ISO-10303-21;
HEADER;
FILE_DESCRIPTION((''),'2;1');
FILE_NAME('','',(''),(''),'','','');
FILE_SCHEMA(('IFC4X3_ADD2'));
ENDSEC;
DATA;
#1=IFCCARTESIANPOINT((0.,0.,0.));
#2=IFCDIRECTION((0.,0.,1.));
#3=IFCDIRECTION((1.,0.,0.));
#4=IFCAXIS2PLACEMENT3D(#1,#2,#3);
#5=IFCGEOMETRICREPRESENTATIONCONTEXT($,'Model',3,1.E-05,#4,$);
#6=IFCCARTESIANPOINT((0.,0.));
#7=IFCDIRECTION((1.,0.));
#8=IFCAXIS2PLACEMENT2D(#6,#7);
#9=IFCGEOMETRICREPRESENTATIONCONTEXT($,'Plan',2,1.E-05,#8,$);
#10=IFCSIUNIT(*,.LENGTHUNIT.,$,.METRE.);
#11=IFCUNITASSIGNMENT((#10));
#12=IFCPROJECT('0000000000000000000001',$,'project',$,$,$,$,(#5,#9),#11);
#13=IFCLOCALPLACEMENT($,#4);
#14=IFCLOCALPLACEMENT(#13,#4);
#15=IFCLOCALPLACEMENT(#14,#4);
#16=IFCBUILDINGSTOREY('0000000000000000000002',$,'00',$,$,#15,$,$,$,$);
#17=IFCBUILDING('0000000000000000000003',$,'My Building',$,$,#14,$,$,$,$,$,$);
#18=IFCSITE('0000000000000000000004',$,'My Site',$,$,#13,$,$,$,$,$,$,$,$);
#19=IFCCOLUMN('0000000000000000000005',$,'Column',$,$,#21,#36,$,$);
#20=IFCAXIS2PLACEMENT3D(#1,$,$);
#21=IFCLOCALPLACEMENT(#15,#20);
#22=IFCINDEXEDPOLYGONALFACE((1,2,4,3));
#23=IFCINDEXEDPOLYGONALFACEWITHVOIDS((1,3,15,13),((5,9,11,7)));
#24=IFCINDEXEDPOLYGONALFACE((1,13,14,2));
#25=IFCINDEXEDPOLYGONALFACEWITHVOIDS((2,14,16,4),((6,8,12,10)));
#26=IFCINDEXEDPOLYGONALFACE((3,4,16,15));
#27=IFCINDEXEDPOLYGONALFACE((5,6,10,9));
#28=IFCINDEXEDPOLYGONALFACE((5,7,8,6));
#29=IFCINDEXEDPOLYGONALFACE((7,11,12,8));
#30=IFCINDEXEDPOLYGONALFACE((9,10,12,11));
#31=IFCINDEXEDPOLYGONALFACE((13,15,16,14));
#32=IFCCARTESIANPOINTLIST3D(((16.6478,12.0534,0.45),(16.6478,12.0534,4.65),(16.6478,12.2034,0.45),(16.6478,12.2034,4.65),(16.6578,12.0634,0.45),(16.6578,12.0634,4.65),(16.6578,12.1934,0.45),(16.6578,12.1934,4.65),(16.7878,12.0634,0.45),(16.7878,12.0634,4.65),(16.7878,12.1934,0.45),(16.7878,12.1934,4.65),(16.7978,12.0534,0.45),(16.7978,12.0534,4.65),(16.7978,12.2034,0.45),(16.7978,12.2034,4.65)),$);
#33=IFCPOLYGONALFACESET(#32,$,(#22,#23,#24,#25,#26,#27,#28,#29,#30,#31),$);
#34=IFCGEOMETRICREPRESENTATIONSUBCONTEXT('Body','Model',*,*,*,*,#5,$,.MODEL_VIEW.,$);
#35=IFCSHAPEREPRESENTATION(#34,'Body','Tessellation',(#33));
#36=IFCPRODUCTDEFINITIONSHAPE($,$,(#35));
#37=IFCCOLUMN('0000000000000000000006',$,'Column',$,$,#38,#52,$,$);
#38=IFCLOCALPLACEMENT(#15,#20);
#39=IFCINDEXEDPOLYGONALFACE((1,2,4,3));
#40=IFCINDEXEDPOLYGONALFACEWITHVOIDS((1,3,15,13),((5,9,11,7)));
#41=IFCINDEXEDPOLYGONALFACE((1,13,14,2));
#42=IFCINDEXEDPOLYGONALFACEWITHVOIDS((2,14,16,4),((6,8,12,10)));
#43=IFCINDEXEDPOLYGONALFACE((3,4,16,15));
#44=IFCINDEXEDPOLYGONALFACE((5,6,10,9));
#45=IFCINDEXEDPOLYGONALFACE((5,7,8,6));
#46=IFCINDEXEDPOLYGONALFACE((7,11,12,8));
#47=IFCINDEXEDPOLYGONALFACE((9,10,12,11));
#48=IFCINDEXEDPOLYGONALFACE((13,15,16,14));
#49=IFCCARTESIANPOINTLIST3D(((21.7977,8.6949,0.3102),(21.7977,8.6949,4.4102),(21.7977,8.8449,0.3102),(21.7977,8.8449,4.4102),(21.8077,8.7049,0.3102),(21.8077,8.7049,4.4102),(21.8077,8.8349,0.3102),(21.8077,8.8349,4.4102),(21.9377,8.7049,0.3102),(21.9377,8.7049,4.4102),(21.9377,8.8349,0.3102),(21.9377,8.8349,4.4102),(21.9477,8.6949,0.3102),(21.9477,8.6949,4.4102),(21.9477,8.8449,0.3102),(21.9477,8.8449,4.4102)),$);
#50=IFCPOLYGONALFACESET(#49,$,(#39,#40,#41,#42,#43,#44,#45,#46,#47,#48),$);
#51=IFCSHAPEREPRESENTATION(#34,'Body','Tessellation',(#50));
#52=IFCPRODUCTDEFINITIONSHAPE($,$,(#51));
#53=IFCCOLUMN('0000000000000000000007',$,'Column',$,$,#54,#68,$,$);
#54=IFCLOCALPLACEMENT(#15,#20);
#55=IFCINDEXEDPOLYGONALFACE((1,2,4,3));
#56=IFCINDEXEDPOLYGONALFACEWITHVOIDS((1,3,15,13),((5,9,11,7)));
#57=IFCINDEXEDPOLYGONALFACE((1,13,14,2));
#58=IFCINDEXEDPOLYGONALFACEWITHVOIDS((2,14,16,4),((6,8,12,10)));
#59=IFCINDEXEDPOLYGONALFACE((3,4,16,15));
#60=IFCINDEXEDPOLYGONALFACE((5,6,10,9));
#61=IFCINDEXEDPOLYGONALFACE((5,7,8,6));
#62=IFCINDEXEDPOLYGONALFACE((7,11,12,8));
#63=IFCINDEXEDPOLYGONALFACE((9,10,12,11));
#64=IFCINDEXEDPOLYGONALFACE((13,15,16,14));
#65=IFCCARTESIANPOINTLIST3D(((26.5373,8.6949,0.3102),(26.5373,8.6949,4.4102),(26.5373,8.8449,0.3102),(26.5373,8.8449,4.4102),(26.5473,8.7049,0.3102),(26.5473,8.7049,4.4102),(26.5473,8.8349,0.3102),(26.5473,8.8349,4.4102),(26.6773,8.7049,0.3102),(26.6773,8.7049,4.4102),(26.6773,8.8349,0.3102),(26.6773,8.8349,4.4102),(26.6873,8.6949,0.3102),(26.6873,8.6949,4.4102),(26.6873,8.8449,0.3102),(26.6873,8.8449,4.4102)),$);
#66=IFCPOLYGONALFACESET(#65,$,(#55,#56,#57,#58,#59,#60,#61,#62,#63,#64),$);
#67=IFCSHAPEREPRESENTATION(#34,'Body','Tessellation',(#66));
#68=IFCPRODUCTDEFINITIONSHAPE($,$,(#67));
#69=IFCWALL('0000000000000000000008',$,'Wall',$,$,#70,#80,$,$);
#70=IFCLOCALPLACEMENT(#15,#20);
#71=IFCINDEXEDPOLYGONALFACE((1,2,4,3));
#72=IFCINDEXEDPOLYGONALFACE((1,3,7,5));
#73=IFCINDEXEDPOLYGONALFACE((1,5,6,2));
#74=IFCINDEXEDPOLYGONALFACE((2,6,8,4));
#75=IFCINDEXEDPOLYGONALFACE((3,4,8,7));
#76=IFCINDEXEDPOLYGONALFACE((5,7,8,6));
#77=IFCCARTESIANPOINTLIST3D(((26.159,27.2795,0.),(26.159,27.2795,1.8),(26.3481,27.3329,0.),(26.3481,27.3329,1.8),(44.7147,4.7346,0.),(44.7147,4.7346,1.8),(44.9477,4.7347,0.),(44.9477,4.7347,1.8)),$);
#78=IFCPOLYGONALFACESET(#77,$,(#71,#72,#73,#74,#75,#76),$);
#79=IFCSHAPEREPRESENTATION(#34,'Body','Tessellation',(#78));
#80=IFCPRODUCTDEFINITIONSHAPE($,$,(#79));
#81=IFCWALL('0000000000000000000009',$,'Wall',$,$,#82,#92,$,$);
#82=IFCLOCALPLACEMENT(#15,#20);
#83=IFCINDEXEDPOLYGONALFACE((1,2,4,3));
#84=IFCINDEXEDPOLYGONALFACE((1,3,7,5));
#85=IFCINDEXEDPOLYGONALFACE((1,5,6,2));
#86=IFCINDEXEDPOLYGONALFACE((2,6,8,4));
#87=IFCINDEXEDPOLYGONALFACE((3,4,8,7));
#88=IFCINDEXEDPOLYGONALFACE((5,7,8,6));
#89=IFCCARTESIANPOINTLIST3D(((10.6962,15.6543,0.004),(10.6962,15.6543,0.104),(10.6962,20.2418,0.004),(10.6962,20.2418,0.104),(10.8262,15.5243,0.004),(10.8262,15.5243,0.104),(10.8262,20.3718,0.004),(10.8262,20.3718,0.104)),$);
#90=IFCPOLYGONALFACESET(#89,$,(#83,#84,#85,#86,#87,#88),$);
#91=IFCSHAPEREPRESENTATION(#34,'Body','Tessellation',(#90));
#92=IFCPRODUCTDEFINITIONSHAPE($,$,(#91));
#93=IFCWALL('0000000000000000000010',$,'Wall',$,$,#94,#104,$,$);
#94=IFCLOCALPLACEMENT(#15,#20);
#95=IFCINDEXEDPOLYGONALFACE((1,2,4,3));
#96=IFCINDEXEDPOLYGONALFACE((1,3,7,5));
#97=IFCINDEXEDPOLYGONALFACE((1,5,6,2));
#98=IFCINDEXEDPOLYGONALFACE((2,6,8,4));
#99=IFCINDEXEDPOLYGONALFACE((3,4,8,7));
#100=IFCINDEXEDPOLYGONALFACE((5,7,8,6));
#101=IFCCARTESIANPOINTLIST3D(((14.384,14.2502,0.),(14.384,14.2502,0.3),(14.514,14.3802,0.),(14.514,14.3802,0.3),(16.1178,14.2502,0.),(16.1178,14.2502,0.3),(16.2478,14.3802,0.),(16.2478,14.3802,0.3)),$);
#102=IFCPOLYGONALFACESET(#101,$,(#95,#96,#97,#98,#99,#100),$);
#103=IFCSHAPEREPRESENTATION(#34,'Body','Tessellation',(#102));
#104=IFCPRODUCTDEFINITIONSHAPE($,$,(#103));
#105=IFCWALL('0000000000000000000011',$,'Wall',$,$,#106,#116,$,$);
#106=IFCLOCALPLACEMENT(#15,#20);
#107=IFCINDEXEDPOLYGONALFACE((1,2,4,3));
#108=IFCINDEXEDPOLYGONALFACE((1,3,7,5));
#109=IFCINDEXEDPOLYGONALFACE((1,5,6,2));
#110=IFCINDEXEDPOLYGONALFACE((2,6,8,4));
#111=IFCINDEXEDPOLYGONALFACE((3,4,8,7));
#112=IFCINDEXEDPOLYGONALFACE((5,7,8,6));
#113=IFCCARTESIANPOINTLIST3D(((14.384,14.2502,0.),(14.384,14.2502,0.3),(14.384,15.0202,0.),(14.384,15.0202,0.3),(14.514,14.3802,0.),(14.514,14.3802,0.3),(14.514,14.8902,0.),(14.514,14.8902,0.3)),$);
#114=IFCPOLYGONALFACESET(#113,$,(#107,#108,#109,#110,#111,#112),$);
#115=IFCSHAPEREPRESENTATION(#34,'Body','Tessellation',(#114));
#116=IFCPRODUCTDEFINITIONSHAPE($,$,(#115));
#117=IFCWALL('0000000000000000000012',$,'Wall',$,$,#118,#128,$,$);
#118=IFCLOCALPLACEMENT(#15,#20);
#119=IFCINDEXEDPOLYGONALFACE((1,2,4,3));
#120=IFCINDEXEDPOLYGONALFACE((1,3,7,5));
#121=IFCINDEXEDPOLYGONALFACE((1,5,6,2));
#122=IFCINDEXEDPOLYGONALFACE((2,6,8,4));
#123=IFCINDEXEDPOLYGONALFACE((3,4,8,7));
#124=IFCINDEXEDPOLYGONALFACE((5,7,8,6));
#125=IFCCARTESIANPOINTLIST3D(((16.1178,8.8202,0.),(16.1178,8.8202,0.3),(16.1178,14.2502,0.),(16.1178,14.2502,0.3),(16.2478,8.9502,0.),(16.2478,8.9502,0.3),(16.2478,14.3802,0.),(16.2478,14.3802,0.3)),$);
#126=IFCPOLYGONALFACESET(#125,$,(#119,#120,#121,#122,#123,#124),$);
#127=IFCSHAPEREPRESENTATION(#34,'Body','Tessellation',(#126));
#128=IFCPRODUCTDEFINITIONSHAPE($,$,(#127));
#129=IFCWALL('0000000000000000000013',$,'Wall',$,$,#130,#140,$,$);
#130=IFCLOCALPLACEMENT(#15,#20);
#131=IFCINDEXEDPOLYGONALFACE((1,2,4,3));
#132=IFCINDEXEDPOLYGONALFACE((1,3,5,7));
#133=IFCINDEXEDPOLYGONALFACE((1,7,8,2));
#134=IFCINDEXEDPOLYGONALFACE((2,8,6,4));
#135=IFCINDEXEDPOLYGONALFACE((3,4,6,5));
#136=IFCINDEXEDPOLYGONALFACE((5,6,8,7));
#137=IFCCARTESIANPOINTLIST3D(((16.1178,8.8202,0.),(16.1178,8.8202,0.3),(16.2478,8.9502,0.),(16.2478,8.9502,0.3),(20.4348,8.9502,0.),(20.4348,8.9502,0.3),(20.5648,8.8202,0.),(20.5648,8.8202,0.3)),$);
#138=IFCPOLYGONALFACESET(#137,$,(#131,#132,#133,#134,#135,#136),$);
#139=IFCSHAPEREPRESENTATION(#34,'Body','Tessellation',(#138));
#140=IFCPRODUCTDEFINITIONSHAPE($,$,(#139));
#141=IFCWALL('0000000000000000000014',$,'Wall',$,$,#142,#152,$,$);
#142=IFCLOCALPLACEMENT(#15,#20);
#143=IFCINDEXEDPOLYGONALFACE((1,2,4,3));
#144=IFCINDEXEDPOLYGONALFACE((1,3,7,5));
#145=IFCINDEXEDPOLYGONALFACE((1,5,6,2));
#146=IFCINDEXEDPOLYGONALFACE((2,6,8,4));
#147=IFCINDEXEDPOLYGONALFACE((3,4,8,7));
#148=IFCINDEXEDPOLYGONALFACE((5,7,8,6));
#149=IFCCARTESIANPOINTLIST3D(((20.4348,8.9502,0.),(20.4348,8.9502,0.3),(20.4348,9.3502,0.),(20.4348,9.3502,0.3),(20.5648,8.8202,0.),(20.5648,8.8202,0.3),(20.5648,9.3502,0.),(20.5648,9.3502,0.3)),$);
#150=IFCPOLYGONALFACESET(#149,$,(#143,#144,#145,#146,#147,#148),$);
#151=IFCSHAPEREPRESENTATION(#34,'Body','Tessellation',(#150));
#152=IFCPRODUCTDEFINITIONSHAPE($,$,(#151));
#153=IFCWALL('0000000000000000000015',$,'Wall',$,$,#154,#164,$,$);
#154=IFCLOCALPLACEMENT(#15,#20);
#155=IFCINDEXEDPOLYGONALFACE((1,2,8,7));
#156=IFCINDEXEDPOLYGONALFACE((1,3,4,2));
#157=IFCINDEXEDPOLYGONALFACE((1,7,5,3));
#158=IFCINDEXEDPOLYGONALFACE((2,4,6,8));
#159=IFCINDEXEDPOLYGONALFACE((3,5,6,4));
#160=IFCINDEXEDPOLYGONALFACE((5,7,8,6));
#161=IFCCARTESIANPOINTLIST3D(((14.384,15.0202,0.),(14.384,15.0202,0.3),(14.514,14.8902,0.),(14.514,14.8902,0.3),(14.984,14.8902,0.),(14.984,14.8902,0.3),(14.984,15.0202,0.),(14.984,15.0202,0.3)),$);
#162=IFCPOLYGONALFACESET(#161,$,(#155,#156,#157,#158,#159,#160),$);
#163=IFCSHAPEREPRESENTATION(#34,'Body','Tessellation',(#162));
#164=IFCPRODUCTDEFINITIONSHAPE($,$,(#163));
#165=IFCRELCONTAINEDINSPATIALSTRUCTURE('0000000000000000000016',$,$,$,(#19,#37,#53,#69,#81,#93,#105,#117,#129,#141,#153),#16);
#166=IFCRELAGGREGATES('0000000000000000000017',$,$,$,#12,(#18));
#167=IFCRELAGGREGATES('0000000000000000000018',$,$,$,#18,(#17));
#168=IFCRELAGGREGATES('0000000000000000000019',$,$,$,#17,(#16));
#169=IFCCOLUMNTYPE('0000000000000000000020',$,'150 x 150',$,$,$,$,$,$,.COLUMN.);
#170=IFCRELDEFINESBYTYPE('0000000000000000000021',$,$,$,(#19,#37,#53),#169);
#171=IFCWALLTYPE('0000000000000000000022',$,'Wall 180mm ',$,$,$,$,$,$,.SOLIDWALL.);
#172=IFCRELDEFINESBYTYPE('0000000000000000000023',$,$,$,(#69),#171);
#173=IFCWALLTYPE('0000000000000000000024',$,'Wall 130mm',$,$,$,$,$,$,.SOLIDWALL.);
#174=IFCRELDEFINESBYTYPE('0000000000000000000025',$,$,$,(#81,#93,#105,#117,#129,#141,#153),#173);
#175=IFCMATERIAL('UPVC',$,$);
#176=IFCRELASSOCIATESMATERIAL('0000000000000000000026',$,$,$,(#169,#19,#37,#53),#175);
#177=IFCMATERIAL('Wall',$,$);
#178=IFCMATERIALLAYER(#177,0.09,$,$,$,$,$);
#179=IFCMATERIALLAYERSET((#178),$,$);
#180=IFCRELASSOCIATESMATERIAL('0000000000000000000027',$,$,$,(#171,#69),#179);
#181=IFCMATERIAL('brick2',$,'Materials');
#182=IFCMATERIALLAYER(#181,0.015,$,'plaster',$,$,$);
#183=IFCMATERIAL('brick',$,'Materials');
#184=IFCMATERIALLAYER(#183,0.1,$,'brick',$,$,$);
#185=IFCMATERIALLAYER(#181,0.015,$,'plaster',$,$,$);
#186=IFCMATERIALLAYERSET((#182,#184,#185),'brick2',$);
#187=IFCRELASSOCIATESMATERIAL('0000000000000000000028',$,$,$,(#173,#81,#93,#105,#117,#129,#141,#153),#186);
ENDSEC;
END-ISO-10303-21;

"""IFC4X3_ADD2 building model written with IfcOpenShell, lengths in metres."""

from ifc_helpers import new_model, entity, si_unit, frame, origin_with_axes, origin_2d_with_axis, place, context, subcontext, project, spatial, line, indexed_curve, hollow_rectangle, outline, extrude, clip, halfspace, shape, material, layer, layer_set, layer_usage, material_profile, profile_set, profile_usage, type_object, element, save


model = new_model("IFC4X3_ADD2")

# Units and contexts
model_context = context("Model", 3, precision=1e-05, world=origin_with_axes())
plan_context = context("Plan", 2, precision=1e-05, world=origin_2d_with_axis())
body_context_1 = subcontext(model_context, "Body", "Model", "MODEL_VIEW")
body_context_2 = subcontext(plan_context, "Body", "Plan", "PLAN_VIEW")
ifc_project = project(units=[si_unit("LENGTHUNIT", "METRE")], contexts=[model_context, plan_context])

# Site, building, storey
site_placement = place(None, origin_with_axes())
site = spatial("IfcSite", under=ifc_project, at=site_placement, Name="My Site")
building_placement = place(site_placement, origin_with_axes())
building = spatial("IfcBuilding", under=site, at=building_placement, Name="My Building")
storey_placement = place(building_placement, origin_with_axes())
storey = spatial("IfcBuildingStorey", under=building, at=storey_placement, Name="00")

# Columns
ifc_material_1 = material(Name="UPVC")
ifc_material_profile = material_profile(ifc_material_1, hollow_rectangle(XDim=0.15, YDim=0.15, WallThickness=0.01))
ifc_profile_set = profile_set([ifc_material_profile])
column_type = type_object("IfcColumnType", Name="150 x 150", PredefinedType="COLUMN", material=ifc_profile_set)
ifc_profile_usage_1 = profile_usage(ifc_profile_set, cardinal=5)
column_1_placement = place(storey_placement, frame((16.7228, 12.1284, 0.45), z_axis=(0.0, 0.0, 1.0), x_axis=(1.0, 0.0, 0.0)))
element("IfcColumn", 1, at=column_1_placement, inside=storey, type_object=column_type, material=ifc_profile_usage_1, Name="Column", shapes=[
    shape(body_context_1, "Body", "SweptSolid", [extrude(hollow_rectangle(XDim=0.15, YDim=0.15, WallThickness=0.01), origin_with_axes(), (0.0, 0.0, 1.0), 4.2)]),
    shape(body_context_2, "Body", "Annotation2D", [entity("IfcGeometricCurveSet", [entity("IfcIndexedPolyCurve", entity("IfcCartesianPointList2D", [[-0.075, -0.075], [-0.075, 0.075], [0.075, 0.075], [0.075, -0.075]]), [entity("IfcLineIndex", [1, 2, 3, 4, 1])]), entity("IfcIndexedPolyCurve", entity("IfcCartesianPointList2D", [[-0.065, 0.065], [-0.065, -0.065], [0.065, -0.065], [0.065, 0.065]]), [entity("IfcLineIndex", [1, 2, 3, 4, 1])])])]),
])
ifc_profile_usage_2 = profile_usage(ifc_profile_set, cardinal=5)
column_2_placement = place(storey_placement, frame((21.8727, 8.7699, 0.3102), z_axis=(0.0, 0.0, 1.0), x_axis=(1.0, 0.0, 0.0)))
element("IfcColumn", 2, at=column_2_placement, inside=storey, type_object=column_type, material=ifc_profile_usage_2, Name="Column", shapes=[
    shape(body_context_1, "Body", "SweptSolid", [extrude(hollow_rectangle(XDim=0.15, YDim=0.15, WallThickness=0.01), origin_with_axes(), (0.0, 0.0, 1.0), 4.1)]),
    shape(body_context_2, "Body", "Annotation2D", [entity("IfcGeometricCurveSet", [entity("IfcIndexedPolyCurve", entity("IfcCartesianPointList2D", [[-0.075, -0.075], [-0.075, 0.075], [0.075, 0.075], [0.075, -0.075]]), [entity("IfcLineIndex", [1, 2, 3, 4, 1])]), entity("IfcIndexedPolyCurve", entity("IfcCartesianPointList2D", [[-0.065, -0.065], [0.065, -0.065], [0.065, 0.065], [-0.065, 0.065]]), [entity("IfcLineIndex", [1, 2, 3, 4, 1])])])]),
])
ifc_profile_usage_3 = profile_usage(ifc_profile_set, cardinal=5)
column_3_placement = place(storey_placement, frame((26.6123, 8.7699, 0.3102), z_axis=(0.0, 0.0, 1.0), x_axis=(1.0, 0.0, 0.0)))
element("IfcColumn", 3, at=column_3_placement, inside=storey, type_object=column_type, material=ifc_profile_usage_3, Name="Column", shapes=[
    shape(body_context_1, "Body", "SweptSolid", [extrude(hollow_rectangle(XDim=0.15, YDim=0.15, WallThickness=0.01), origin_with_axes(), (0.0, 0.0, 1.0), 4.1)]),
    shape(body_context_2, "Body", "Annotation2D", [entity("IfcGeometricCurveSet", [entity("IfcIndexedPolyCurve", entity("IfcCartesianPointList2D", [[-0.075, -0.075], [-0.075, 0.075], [0.075, 0.075], [0.075, -0.075]]), [entity("IfcLineIndex", [1, 2, 3, 4, 1])]), entity("IfcIndexedPolyCurve", entity("IfcCartesianPointList2D", [[-0.065, -0.065], [0.065, -0.065], [0.065, 0.065], [-0.065, 0.065]]), [entity("IfcLineIndex", [1, 2, 3, 4, 1])])])]),
])

# Walls
ifc_material_2 = material(Name="Wall")
ifc_layer_1 = layer(ifc_material_2, 0.09)
ifc_layer_set_1 = layer_set([ifc_layer_1])
wall_type_1 = type_object("IfcWallType", Name="Wall 180mm ", PredefinedType="SOLIDWALL", material=ifc_layer_set_1)
ifc_layer_usage_1 = layer_usage(ifc_layer_set_1, "AXIS2", "POSITIVE", 0.0)
wall_1_placement = place(storey_placement, frame((44.9477, 4.7347, 0.0), z_axis=(0.0, 0.0, 1.0), x_axis=(-0.635489, 0.77211, 0.0)))
element("IfcWall", 4, at=wall_1_placement, inside=storey, type_object=wall_type_1, material=ifc_layer_usage_1, Name="Wall", context=body_context_1, shape_type="Clipping", body=[
    clip(clip(extrude(outline(indexed_curve([(0.0, 0.0), (0.0, 0.18), (29.3471, 0.18), (29.3471, 0.0), (0.0, 0.0)], self_intersect=False)), origin_with_axes(), (0.0, 0.0, 1.0), 1.8), halfspace(frame((0.0, 0.0, 0.0), z_axis=(-0.772377, 0.635165, 0.0), x_axis=(0.635165, 0.772377, 0.0)), False)), halfspace(frame((29.2681, 0.0, 0.0), z_axis=(0.915717, -0.401825, 0.0), x_axis=(-0.401825, -0.915717, 0.0)), False)),
])
ifc_material_3 = material(Name="brick2", Category="Materials")
ifc_layer_2 = layer(ifc_material_3, 0.015, Name="plaster")
ifc_material_4 = material(Name="brick", Category="Materials")
ifc_layer_3 = layer(ifc_material_4, 0.1, Name="brick")
ifc_layer_4 = layer(ifc_material_3, 0.015, Name="plaster")
ifc_layer_set_2 = layer_set([ifc_layer_2, ifc_layer_3, ifc_layer_4], Name="brick2")
ifc_layer_usage_2 = layer_usage(ifc_layer_set_2, "AXIS2", "POSITIVE", 0.0)
wall_type_2 = type_object("IfcWallType", Name="Wall 130mm", PredefinedType="SOLIDWALL", material=ifc_layer_set_2)
wall_2_placement = place(storey_placement, frame((10.8262, 15.6543, 0.004), z_axis=(0.0, 0.0, 1.0), x_axis=(0.000001, 1.0, 0.0)))
element("IfcWall", 5, at=wall_2_placement, inside=storey, type_object=wall_type_2, material=ifc_layer_usage_2, Name="Wall", context=body_context_1, shape_type="SweptSolid", body=[
    extrude(outline(indexed_curve([(-0.13, 0.0), (0.0, 0.13), (4.5875, 0.13), (4.7175, 0.0)], segments=[line(1, 2, 3, 4, 1)])), origin_with_axes(), (0.0, 0.0, 1.0), 0.1),
])
ifc_layer_usage_3 = layer_usage(ifc_layer_set_2, "AXIS2", "POSITIVE", 0.0)
wall_3_placement = place(storey_placement, frame((14.514, 14.2502, 0.0), z_axis=(0.0, 0.0, 1.0), x_axis=(1.0, 0.0, 0.0)))
element("IfcWall", 6, at=wall_3_placement, inside=storey, type_object=wall_type_2, material=ifc_layer_usage_3, Name="Wall", context=body_context_1, shape_type="SweptSolid", body=[
    extrude(outline(indexed_curve([(-0.13, 0.0), (0.0, 0.13), (1.7338, 0.13), (1.6038, 0.0)], segments=[line(1, 2, 3, 4, 1)])), origin_with_axes(), (0.0, 0.0, 1.0), 0.3),
])
ifc_layer_usage_4 = layer_usage(ifc_layer_set_2, "AXIS2", "POSITIVE", 0.0)
wall_4_placement = place(storey_placement, frame((14.514, 14.2502, 0.0), z_axis=(0.0, 0.0, 1.0), x_axis=(0.0, 1.0, 0.0)))
element("IfcWall", 7, at=wall_4_placement, inside=storey, type_object=wall_type_2, material=ifc_layer_usage_4, Name="Wall", context=body_context_1, shape_type="SweptSolid", body=[
    extrude(outline(indexed_curve([(0.13, 0.0), (0.0, 0.13), (0.77, 0.13), (0.64, 0.0)], segments=[line(1, 2, 3, 4, 1)])), origin_with_axes(), (0.0, 0.0, 1.0), 0.3),
])
ifc_layer_usage_5 = layer_usage(ifc_layer_set_2, "AXIS2", "POSITIVE", 0.0)
wall_5_placement = place(storey_placement, frame((16.2478, 8.8202, 0.0), z_axis=(0.0, 0.0, 1.0), x_axis=(0.0, 1.0, 0.0)))
element("IfcWall", 8, at=wall_5_placement, inside=storey, type_object=wall_type_2, material=ifc_layer_usage_5, Name="Wall", context=body_context_1, shape_type="SweptSolid", body=[
    extrude(outline(indexed_curve([(0.13, 0.0), (0.0, 0.13), (5.43, 0.13), (5.56, 0.0)], segments=[line(1, 2, 3, 4, 1)])), origin_with_axes(), (0.0, 0.0, 1.0), 0.3),
])
ifc_layer_usage_6 = layer_usage(ifc_layer_set_2, "AXIS2", "POSITIVE", 0.0)
wall_6_placement = place(storey_placement, frame((16.2478, 8.8202, 0.0), z_axis=(0.0, 0.0, 1.0), x_axis=(1.0, 0.0, 0.0)))
element("IfcWall", 9, at=wall_6_placement, inside=storey, type_object=wall_type_2, material=ifc_layer_usage_6, Name="Wall", context=body_context_1, shape_type="SweptSolid", body=[
    extrude(outline(indexed_curve([(-0.13, 0.0), (0.0, 0.13), (4.187, 0.13), (4.317, 0.0)], segments=[line(1, 2, 3, 4, 1)])), origin_with_axes(), (0.0, 0.0, 1.0), 0.3),
])
ifc_layer_usage_7 = layer_usage(ifc_layer_set_2, "AXIS2", "POSITIVE", 0.0)
wall_7_placement = place(storey_placement, frame((20.5648, 8.8202, 0.0), z_axis=(0.0, 0.0, 1.0), x_axis=(0.0, 1.0, 0.0)))
element("IfcWall", 10, at=wall_7_placement, inside=storey, type_object=wall_type_2, material=ifc_layer_usage_7, Name="Wall", context=body_context_1, shape_type="SweptSolid", body=[
    extrude(outline(indexed_curve([(0.0, 0.0), (0.13, 0.13), (0.53, 0.13), (0.53, 0.0)], segments=[line(1, 2, 3, 4, 1)])), origin_with_axes(), (0.0, 0.0, 1.0), 0.3),
])
ifc_layer_usage_8 = layer_usage(ifc_layer_set_2, "AXIS2", "POSITIVE", 0.0)
wall_8_placement = place(storey_placement, frame((14.514, 14.8902, 0.0), z_axis=(0.0, 0.0, 1.0), x_axis=(1.0, 0.0, 0.0)))
element("IfcWall", 11, at=wall_8_placement, inside=storey, type_object=wall_type_2, material=ifc_layer_usage_8, Name="Wall", context=body_context_1, shape_type="SweptSolid", body=[
    extrude(outline(indexed_curve([(0.0, 0.0), (-0.13, 0.13), (0.47, 0.13), (0.47, 0.0)], segments=[line(1, 2, 3, 4, 1)])), origin_with_axes(), (0.0, 0.0, 1.0), 0.3),
])

save(model, "model.ifc")
